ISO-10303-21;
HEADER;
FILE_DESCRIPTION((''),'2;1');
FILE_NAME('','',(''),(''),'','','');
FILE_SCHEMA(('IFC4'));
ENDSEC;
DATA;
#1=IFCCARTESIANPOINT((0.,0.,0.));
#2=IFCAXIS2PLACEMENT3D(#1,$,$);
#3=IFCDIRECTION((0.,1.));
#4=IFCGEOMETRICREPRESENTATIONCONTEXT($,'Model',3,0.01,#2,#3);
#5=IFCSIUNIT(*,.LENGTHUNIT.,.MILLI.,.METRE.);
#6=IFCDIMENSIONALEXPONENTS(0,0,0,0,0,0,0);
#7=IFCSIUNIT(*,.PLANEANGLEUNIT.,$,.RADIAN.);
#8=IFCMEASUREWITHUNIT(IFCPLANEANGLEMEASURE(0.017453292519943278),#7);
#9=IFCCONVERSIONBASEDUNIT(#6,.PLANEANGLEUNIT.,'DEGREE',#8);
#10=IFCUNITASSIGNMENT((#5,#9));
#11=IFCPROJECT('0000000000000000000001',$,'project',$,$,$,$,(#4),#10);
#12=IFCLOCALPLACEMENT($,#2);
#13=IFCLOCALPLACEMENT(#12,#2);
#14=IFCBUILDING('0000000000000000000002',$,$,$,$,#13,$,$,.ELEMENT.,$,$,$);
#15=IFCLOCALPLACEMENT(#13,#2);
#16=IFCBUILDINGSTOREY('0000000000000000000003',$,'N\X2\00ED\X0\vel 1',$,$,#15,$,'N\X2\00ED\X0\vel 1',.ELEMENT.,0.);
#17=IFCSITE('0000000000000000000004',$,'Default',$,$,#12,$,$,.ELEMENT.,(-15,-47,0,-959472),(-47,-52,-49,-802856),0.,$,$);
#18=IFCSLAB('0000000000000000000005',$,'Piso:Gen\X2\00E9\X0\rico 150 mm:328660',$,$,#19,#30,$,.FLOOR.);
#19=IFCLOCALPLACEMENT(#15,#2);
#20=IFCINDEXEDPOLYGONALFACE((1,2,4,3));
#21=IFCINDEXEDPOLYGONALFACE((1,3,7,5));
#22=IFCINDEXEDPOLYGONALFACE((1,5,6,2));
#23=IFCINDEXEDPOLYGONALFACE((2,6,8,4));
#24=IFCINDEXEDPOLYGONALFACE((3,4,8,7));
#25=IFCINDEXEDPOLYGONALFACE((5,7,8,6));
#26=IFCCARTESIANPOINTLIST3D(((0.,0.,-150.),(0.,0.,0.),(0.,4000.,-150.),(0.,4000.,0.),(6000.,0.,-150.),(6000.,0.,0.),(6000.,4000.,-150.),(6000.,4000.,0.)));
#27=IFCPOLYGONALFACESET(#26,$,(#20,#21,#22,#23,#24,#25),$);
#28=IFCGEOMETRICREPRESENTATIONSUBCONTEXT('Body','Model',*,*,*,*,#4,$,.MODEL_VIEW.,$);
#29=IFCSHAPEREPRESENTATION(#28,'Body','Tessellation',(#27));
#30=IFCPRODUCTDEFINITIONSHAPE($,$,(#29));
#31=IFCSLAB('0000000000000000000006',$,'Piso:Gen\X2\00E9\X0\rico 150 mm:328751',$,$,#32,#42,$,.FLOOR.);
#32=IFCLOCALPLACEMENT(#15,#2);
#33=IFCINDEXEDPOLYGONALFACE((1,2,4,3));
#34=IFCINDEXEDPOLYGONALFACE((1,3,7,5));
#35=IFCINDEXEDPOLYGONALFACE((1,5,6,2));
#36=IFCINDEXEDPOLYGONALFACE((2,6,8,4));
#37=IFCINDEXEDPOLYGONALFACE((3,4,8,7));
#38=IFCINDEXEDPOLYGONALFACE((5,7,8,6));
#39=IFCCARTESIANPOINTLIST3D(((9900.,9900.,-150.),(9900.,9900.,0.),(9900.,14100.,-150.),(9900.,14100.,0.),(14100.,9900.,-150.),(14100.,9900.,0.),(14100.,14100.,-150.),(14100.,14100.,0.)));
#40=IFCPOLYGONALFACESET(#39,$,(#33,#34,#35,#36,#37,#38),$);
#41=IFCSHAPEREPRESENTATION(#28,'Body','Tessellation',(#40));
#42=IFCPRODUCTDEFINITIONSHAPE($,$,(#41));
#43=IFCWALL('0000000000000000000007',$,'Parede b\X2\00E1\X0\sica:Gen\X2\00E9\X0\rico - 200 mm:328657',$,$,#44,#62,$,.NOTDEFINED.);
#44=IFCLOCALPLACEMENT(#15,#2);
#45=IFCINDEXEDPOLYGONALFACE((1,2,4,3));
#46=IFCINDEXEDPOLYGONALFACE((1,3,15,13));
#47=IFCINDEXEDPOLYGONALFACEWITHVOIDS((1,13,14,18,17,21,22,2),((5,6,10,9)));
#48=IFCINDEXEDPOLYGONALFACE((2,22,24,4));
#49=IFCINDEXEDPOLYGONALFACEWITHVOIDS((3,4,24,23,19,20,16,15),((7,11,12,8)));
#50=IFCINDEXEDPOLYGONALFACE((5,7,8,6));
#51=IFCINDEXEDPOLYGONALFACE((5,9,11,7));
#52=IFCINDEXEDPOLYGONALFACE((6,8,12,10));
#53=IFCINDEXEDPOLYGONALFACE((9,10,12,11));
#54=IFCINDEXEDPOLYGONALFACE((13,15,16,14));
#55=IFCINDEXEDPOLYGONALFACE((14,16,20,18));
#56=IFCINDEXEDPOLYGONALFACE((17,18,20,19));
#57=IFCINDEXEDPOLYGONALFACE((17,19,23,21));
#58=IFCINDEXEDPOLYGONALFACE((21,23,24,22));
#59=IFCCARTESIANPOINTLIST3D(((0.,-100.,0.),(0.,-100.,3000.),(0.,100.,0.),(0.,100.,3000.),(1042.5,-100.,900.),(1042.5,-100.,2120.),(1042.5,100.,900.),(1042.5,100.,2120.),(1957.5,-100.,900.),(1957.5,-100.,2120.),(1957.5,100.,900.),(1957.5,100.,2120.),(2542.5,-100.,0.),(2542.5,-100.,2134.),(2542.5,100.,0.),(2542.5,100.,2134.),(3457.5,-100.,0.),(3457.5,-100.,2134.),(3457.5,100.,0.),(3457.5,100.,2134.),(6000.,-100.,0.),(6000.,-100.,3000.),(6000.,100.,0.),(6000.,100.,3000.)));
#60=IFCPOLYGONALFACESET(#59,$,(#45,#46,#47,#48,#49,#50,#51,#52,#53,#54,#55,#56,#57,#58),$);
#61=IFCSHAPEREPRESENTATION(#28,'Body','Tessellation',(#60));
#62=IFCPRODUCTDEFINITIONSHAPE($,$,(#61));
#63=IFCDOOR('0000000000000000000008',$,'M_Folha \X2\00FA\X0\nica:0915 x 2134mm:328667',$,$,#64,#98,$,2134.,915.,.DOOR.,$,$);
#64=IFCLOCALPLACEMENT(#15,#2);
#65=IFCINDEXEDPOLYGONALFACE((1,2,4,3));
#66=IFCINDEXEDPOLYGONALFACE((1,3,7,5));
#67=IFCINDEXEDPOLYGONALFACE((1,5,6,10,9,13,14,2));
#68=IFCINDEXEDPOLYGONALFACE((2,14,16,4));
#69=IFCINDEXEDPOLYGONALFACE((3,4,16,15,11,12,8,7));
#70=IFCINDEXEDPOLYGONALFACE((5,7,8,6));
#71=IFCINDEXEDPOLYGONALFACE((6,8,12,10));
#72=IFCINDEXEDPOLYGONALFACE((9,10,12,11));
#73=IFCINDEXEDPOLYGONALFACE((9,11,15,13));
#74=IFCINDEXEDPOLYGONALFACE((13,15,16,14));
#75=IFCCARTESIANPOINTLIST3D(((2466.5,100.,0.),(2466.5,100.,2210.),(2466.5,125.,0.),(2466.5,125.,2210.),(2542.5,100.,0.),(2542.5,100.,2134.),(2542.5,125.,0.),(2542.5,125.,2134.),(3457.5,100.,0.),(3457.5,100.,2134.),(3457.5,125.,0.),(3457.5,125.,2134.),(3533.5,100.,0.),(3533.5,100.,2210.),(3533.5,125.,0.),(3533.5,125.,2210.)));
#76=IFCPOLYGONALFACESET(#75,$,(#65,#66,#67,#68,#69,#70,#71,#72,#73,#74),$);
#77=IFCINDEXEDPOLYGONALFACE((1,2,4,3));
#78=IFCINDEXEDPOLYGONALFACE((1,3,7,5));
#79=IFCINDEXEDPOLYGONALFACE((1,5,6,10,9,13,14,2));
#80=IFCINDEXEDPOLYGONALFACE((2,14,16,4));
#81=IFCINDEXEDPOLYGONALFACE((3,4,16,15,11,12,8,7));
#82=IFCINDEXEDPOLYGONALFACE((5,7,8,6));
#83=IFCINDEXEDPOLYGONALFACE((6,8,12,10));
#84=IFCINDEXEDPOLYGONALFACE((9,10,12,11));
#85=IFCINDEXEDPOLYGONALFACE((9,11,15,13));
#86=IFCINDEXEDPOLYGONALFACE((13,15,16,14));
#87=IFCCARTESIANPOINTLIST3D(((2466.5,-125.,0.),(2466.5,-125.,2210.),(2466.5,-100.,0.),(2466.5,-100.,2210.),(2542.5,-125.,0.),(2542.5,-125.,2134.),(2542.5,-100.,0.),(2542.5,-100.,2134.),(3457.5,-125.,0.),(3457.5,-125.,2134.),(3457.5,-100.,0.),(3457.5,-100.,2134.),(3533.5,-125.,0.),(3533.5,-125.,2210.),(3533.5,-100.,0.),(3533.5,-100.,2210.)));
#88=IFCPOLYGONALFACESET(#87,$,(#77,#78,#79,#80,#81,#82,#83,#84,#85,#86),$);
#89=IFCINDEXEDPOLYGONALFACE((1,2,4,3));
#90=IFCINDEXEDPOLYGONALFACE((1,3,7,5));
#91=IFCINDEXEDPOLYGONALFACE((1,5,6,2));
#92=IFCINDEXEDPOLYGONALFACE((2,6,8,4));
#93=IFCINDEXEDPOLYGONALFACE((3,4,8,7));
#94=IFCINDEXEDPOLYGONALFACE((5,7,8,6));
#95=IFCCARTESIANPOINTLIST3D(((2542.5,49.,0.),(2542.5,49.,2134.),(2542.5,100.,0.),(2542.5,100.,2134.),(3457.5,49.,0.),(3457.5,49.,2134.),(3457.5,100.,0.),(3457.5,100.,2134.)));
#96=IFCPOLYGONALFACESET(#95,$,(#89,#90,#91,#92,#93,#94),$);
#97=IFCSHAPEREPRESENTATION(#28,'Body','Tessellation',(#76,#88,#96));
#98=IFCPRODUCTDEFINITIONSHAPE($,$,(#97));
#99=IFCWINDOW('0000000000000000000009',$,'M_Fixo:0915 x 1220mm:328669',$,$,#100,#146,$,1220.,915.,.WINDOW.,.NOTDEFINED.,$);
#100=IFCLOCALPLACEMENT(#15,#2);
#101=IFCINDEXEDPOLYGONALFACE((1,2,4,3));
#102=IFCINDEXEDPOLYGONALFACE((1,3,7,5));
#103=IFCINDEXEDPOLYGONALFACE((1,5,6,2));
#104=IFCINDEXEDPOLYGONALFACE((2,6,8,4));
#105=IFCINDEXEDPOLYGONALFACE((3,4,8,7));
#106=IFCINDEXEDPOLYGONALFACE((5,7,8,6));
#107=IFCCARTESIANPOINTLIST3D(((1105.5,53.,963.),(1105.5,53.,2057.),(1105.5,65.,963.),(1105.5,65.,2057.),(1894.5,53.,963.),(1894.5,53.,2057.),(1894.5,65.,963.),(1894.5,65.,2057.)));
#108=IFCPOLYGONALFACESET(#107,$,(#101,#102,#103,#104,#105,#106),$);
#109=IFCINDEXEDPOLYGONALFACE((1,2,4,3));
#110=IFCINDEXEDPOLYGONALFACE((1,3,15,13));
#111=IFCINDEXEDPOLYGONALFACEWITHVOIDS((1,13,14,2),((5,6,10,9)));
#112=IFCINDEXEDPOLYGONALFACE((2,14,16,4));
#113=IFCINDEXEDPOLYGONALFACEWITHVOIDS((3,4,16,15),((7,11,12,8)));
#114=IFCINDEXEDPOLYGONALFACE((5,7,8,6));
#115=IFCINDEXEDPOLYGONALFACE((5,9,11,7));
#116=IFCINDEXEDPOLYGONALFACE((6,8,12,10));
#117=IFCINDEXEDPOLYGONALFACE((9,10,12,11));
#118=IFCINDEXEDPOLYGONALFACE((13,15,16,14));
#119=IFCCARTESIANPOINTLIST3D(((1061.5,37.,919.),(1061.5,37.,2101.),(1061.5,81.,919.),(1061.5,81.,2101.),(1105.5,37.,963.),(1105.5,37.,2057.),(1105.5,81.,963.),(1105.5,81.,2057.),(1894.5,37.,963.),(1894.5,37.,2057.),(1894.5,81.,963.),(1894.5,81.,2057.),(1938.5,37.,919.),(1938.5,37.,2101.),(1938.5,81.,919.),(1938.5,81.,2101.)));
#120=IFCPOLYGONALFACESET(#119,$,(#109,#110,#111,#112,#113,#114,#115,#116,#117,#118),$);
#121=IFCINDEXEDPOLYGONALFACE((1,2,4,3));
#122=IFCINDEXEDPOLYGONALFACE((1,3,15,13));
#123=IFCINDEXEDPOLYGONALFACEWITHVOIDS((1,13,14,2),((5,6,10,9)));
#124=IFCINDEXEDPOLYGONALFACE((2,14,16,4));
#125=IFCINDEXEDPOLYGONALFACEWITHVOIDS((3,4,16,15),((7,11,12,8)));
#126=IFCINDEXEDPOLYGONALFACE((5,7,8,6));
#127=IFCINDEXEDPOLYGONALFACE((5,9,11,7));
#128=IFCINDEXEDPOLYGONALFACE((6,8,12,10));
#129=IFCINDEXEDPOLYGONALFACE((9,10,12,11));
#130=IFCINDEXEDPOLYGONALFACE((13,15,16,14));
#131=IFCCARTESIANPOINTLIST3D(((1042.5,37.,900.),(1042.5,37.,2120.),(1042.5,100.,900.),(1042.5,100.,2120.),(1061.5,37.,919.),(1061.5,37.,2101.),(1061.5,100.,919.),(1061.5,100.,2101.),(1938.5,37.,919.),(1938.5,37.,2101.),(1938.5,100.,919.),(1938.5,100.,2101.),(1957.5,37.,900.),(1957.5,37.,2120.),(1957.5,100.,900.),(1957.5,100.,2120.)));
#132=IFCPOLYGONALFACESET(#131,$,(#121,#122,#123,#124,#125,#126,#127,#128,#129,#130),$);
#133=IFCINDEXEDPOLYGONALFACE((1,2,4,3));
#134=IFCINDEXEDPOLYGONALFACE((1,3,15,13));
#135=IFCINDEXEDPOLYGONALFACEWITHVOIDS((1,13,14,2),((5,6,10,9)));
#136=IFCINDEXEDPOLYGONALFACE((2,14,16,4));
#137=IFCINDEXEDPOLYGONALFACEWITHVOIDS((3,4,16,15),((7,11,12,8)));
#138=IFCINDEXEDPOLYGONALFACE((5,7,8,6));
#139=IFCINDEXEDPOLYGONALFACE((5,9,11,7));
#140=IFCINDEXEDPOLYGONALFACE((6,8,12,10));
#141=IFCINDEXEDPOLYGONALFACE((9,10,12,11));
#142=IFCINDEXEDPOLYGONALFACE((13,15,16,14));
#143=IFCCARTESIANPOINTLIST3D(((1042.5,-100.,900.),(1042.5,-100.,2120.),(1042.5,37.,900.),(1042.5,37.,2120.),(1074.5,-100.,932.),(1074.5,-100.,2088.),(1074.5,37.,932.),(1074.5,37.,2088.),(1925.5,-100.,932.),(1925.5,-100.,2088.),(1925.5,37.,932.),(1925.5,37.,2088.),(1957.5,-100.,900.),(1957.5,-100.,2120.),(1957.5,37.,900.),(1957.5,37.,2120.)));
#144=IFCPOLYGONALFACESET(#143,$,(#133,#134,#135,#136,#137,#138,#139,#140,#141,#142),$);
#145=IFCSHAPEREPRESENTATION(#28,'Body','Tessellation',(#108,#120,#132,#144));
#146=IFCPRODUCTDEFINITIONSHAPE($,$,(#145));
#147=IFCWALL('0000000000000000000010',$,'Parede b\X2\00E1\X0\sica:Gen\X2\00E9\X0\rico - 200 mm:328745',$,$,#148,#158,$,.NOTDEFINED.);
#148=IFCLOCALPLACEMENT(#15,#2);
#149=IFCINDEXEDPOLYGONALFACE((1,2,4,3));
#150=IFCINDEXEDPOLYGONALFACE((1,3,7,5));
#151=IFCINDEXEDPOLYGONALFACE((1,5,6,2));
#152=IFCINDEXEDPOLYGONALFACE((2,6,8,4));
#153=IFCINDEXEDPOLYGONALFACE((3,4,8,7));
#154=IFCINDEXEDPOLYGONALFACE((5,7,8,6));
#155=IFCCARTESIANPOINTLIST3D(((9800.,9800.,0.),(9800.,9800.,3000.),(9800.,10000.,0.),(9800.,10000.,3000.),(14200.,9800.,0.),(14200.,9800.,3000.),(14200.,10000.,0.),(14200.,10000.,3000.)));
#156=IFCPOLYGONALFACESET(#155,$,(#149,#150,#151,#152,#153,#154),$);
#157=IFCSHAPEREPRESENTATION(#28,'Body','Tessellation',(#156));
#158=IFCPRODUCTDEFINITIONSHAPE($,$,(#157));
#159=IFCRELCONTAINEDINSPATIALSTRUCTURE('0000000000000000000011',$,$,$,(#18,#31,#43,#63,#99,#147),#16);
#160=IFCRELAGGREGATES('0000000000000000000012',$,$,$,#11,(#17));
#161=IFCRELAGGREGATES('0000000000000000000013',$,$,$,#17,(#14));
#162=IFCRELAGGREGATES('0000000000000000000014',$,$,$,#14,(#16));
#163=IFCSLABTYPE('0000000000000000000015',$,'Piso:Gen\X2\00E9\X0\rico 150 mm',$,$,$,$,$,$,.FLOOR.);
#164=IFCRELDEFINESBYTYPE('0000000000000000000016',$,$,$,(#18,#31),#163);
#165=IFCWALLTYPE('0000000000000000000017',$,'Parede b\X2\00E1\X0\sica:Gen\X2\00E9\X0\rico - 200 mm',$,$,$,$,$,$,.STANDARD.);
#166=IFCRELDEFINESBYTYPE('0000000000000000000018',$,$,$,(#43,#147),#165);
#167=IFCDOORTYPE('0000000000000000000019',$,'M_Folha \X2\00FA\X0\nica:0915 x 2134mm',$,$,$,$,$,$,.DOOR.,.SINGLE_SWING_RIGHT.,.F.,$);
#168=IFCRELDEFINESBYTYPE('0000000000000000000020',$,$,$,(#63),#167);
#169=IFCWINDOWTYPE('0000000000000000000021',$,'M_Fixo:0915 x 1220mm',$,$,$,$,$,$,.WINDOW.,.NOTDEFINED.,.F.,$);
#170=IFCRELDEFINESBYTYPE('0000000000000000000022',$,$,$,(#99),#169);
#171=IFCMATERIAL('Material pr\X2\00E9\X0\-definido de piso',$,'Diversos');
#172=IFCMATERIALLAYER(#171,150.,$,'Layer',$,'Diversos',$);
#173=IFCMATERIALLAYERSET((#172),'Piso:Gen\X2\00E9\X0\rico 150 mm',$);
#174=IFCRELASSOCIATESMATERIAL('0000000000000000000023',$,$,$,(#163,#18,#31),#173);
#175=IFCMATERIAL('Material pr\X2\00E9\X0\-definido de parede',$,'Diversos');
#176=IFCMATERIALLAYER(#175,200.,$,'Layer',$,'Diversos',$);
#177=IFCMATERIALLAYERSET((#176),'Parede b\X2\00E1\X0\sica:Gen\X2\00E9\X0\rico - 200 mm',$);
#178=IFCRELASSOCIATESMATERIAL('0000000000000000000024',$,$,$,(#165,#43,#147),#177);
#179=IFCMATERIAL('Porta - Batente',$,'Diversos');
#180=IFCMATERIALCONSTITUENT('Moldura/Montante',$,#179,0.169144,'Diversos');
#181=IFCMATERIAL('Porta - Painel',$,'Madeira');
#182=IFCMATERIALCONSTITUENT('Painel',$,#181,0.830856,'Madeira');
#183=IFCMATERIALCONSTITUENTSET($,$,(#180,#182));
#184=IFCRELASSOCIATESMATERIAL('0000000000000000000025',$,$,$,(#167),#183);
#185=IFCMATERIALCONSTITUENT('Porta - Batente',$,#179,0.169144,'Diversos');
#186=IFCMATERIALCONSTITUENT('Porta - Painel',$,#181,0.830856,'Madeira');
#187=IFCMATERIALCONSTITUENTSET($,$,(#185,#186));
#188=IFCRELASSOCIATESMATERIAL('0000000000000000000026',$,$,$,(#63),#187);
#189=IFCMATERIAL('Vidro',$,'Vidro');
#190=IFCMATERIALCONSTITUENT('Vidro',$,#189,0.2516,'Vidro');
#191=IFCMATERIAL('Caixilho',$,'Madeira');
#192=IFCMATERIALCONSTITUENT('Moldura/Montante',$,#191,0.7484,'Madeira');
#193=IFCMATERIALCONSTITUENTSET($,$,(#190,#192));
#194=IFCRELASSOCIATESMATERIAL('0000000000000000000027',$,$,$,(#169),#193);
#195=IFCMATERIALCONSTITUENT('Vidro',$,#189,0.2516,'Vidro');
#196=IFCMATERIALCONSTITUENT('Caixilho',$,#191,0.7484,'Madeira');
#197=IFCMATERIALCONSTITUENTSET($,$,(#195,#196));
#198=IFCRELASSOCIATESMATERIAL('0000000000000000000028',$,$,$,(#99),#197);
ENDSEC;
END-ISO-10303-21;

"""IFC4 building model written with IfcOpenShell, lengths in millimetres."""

from ifc_helpers import new_model, entity, si_unit, converted_unit, direction, frame, frame_2d, origin, origin_2d_with_axis, place, context, subcontext, project, spatial, polyline, rectangle, outline, extrude, source, transform, mapped, material, layer, layer_set, layer_usage, constituent, constituent_set, type_object, type_shapes, element, fill, save


model = new_model("IFC4")

# Units and contexts
model_context = context("Model", 3, precision=0.01, world=origin(), true_north=direction((0.0, 1.0)))
body_context = subcontext(model_context, "Body", "Model", "MODEL_VIEW")
ifc_project = project(units=[si_unit("LENGTHUNIT", "METRE", prefix="MILLI"), converted_unit("PLANEANGLEUNIT", "DEGREE", entity("IfcPlaneAngleMeasure", 0.017453292519943278), si_unit("PLANEANGLEUNIT", "RADIAN"), dimensions=[0, 0, 0, 0, 0, 0, 0])], contexts=[model_context])

# Site, building, storey
site_placement = place(None, origin())
site = spatial("IfcSite", under=ifc_project, at=site_placement, Name="Default", CompositionType="ELEMENT", RefLatitude=(-15, -47, 0, -959472), RefLongitude=(-47, -52, -49, -802856), RefElevation=0.0)
building_placement = place(site_placement, origin())
building = spatial("IfcBuilding", under=site, at=building_placement, CompositionType="ELEMENT")
storey_placement = place(building_placement, origin())
storey = spatial("IfcBuildingStorey", under=building, at=storey_placement, Name="Nível 1", LongName="Nível 1", CompositionType="ELEMENT", Elevation=0.0)

# Slabs
ifc_material_1 = material(Name="Material pré-definido de piso", Category="Diversos")
ifc_layer_1 = layer(ifc_material_1, 150.0, Name="Layer", Category="Diversos")
ifc_layer_set_1 = layer_set([ifc_layer_1], Name="Piso:Genérico 150 mm")
ifc_layer_usage_1 = layer_usage(ifc_layer_set_1, "AXIS3", "POSITIVE", 0.0)
slab_type = type_object("IfcSlabType", Name="Piso:Genérico 150 mm", PredefinedType="FLOOR", material=ifc_layer_set_1)
slab_1_placement = place(storey_placement, origin())
element("IfcSlab", 1, at=slab_1_placement, inside=storey, type_object=slab_type, material=ifc_layer_usage_1, Name="Piso:Genérico 150 mm:328660", PredefinedType="FLOOR", context=body_context, shape_type="SweptSolid", body=[
    extrude(rectangle(XDim=4000.0, YDim=6000.0, at=origin_2d_with_axis()), frame((3000.0, 2000.0, 0.0), z_axis=(0.0, 0.0, -1.0), x_axis=(0.0, 1.0, 0.0)), (0.0, 0.0, 1.0), 150.0),
])
ifc_layer_usage_2 = layer_usage(ifc_layer_set_1, "AXIS3", "POSITIVE", 0.0)
slab_2_placement = place(storey_placement, origin())
element("IfcSlab", 2, at=slab_2_placement, inside=storey, type_object=slab_type, material=ifc_layer_usage_2, Name="Piso:Genérico 150 mm:328751", PredefinedType="FLOOR", context=body_context, shape_type="SweptSolid", body=[
    extrude(rectangle(XDim=4200.0, YDim=4200.0, at=origin_2d_with_axis()), frame((12000.0, 12000.0, 0.0), z_axis=(0.0, 0.0, -1.0), x_axis=(0.0, 1.0, 0.0)), (0.0, 0.0, 1.0), 150.0),
])

# Wall, openings, door, window
ifc_material_2 = material(Name="Material pré-definido de parede", Category="Diversos")
ifc_layer_2 = layer(ifc_material_2, 200.0, Name="Layer", Category="Diversos")
ifc_layer_set_2 = layer_set([ifc_layer_2], Name="Parede básica:Genérico - 200 mm")
ifc_layer_usage_3 = layer_usage(ifc_layer_set_2, "AXIS2", "NEGATIVE", 100.0)
wall_type = type_object("IfcWallType", Name="Parede básica:Genérico - 200 mm", PredefinedType="STANDARD", material=ifc_layer_set_2)
wall_1_placement = place(storey_placement, origin())
wall_1 = element("IfcWall", 3, at=wall_1_placement, inside=storey, type_object=wall_type, material=ifc_layer_usage_3, Name="Parede básica:Genérico - 200 mm:328657", PredefinedType="NOTDEFINED", context=body_context, shape_type="SweptSolid", body=[
    extrude(rectangle(XDim=6000.0, YDim=200.0, at=frame_2d((3000.0, 0.0), x_axis=(1.0, 0.0))), origin(), (0.0, 0.0, 1.0), 3000.0),
])
opening_1_placement = place(wall_1_placement, frame((2542.5, -100.0, 0.0)))
opening_1 = element("IfcOpeningElement", 4, at=opening_1_placement, cuts=wall_1, PredefinedType="OPENING", context=body_context, shape_type="SweptSolid", body=[
    extrude(rectangle(XDim=915.0, YDim=2134.0, at=frame_2d((1067.0, 457.5), x_axis=(0.0, 1.0))), frame((0.0, 0.0, 0.0), z_axis=(0.0, 1.0, 0.0), x_axis=(0.0, 0.0, 1.0)), (0.0, 0.0, 1.0), 200.0),
])
opening_2_placement = place(wall_1_placement, frame((1042.5, -100.0, 900.0)))
opening_2 = element("IfcOpeningElement", 5, at=opening_2_placement, cuts=wall_1, PredefinedType="OPENING", context=body_context, shape_type="SweptSolid", body=[
    extrude(rectangle(XDim=1220.0, YDim=915.0, at=frame_2d((610.0, 457.5), x_axis=(1.0, 0.0))), frame((0.0, 0.0, 0.0), z_axis=(0.0, 1.0, 0.0), x_axis=(0.0, 0.0, 1.0)), (0.0, 0.0, 1.0), 200.0),
])
ifc_material_3 = material(Name="Porta - Batente", Category="Diversos")
ifc_constituent_1 = constituent(ifc_material_3, Name="Porta - Batente", Category="Diversos", fraction=0.169144)
ifc_material_4 = material(Name="Porta - Painel", Category="Madeira")
ifc_constituent_2 = constituent(ifc_material_4, Name="Porta - Painel", Category="Madeira", fraction=0.830856)
ifc_constituent_set_1 = constituent_set(constituents=[ifc_constituent_1, ifc_constituent_2])
ifc_constituent_3 = constituent(ifc_material_3, Name="Moldura/Montante", Category="Diversos", fraction=0.169144)
ifc_constituent_4 = constituent(ifc_material_4, Name="Painel", Category="Madeira", fraction=0.830856)
ifc_constituent_set_2 = constituent_set(constituents=[ifc_constituent_3, ifc_constituent_4])
door_type = type_object("IfcDoorType", Name="M_Folha única:0915 x 2134mm", OperationType="SINGLE_SWING_RIGHT", ParameterTakesPrecedence=False, PredefinedType="DOOR", material=ifc_constituent_set_2)
shared_shape_1 = source(origin(), body_context, "Body", "SweptSolid", [
    extrude(outline(polyline([(-533.5, -1124.0), (533.5, -1124.0), (533.5, 1086.0), (457.5, 1086.0), (457.5, -1048.0), (-457.5, -1048.0), (-457.5, 1086.0), (-533.5, 1086.0), (-533.5, -1124.0)])), frame((457.5, 200.0, 1086.0), z_axis=(0.0, 1.0, 0.0), x_axis=(1.0, 0.0, 0.0)), (0.0, 0.0, 1.0), 25.0),
    extrude(outline(polyline([(-1124.0, -533.5), (1086.0, -533.5), (1086.0, -457.5), (-1048.0, -457.5), (-1048.0, 457.5), (1086.0, 457.5), (1086.0, 533.5), (-1124.0, 533.5), (-1124.0, -533.5)])), frame((457.5, -25.0, 1086.0), z_axis=(0.0, 1.0, 0.0), x_axis=(0.0, 0.0, -1.0)), (0.0, 0.0, 1.0), 25.0),
    extrude(rectangle(XDim=51.0, YDim=915.0, at=frame_2d((0.0, 0.0), x_axis=(1.0, 0.0))), frame((457.5, 174.5, 0.0), z_axis=(0.0, 0.0, 1.0), x_axis=(0.0, 1.0, 0.0)), (0.0, 0.0, 1.0), 2134.0),
])
type_shapes(door_type, [shared_shape_1])
door_placement = place(opening_1_placement, origin())
door = element("IfcDoor", 6, at=door_placement, inside=storey, type_object=door_type, material=ifc_constituent_set_1, Name="M_Folha única:0915 x 2134mm:328667", OverallHeight=2134.0, OverallWidth=915.0, PredefinedType="DOOR", context=body_context, shape_type="MappedRepresentation", body=[
    mapped(shared_shape_1, transform((0.0, 0.0, 0.0), scale=1.0)),
])
fill(opening_1, door)
ifc_material_5 = material(Name="Vidro", Category="Vidro")
ifc_constituent_5 = constituent(ifc_material_5, Name="Vidro", Category="Vidro", fraction=0.2516)
ifc_material_6 = material(Name="Caixilho", Category="Madeira")
ifc_constituent_6 = constituent(ifc_material_6, Name="Caixilho", Category="Madeira", fraction=0.7484)
ifc_constituent_set_3 = constituent_set(constituents=[ifc_constituent_5, ifc_constituent_6])
ifc_constituent_7 = constituent(ifc_material_5, Name="Vidro", Category="Vidro", fraction=0.2516)
ifc_constituent_8 = constituent(ifc_material_6, Name="Moldura/Montante", Category="Madeira", fraction=0.7484)
ifc_constituent_set_4 = constituent_set(constituents=[ifc_constituent_7, ifc_constituent_8])
window_type = type_object("IfcWindowType", Name="M_Fixo:0915 x 1220mm", ParameterTakesPrecedence=False, PartitioningType="NOTDEFINED", PredefinedType="WINDOW", material=ifc_constituent_set_4)
shared_shape_2 = source(origin(), body_context, "Body", "SweptSolid", [
    extrude(rectangle(XDim=12.0, YDim=789.0, at=frame_2d((0.0, 0.0), x_axis=(1.0, 0.0))), frame((457.5, 159.0, 63.0), z_axis=(0.0, 0.0, 1.0), x_axis=(0.0, -1.0, 0.0)), (0.0, 0.0, 1.0), 1094.0),
    extrude(outline(polyline([(-438.5, -591.0), (438.5, -591.0), (438.5, 591.0), (-438.5, 591.0), (-438.5, -591.0)]), holes=[polyline([(-394.5, -547.0), (-394.5, 547.0), (394.5, 547.0), (394.5, -547.0), (-394.5, -547.0)])]), frame((457.5, 137.0, 610.0), z_axis=(0.0, 1.0, 0.0), x_axis=(1.0, 0.0, 0.0)), (0.0, 0.0, 1.0), 44.0),
    extrude(outline(polyline([(-457.5, -610.0), (457.5, -610.0), (457.5, 610.0), (-457.5, 610.0), (-457.5, -610.0)]), holes=[polyline([(-438.5, -591.0), (-438.5, 591.0), (438.5, 591.0), (438.5, -591.0), (-438.5, -591.0)])]), frame((457.5, 137.0, 610.0), z_axis=(0.0, 1.0, 0.0), x_axis=(1.0, 0.0, 0.0)), (0.0, 0.0, 1.0), 63.0),
    extrude(outline(polyline([(-457.5, -610.0), (457.5, -610.0), (457.5, 610.0), (-457.5, 610.0), (-457.5, -610.0)]), holes=[polyline([(-425.5, -578.0), (-425.5, 578.0), (425.5, 578.0), (425.5, -578.0), (-425.5, -578.0)])]), frame((457.5, 0.0, 610.0), z_axis=(0.0, 1.0, 0.0), x_axis=(1.0, 0.0, 0.0)), (0.0, 0.0, 1.0), 137.0),
])
type_shapes(window_type, [shared_shape_2])
window_placement = place(opening_2_placement, origin())
window = element("IfcWindow", 7, at=window_placement, inside=storey, type_object=window_type, material=ifc_constituent_set_3, Name="M_Fixo:0915 x 1220mm:328669", OverallHeight=1220.0, OverallWidth=915.0, PartitioningType="NOTDEFINED", PredefinedType="WINDOW", context=body_context, shape_type="MappedRepresentation", body=[
    mapped(shared_shape_2, transform((0.0, 0.0, 0.0), scale=1.0)),
])
fill(opening_2, window)

# Wall
ifc_layer_usage_4 = layer_usage(ifc_layer_set_2, "AXIS2", "NEGATIVE", 100.0)
wall_2_placement = place(storey_placement, frame((9800.0, 9900.0, 0.0)))
element("IfcWall", 8, at=wall_2_placement, inside=storey, type_object=wall_type, material=ifc_layer_usage_4, Name="Parede básica:Genérico - 200 mm:328745", PredefinedType="NOTDEFINED", context=body_context, shape_type="SweptSolid", body=[
    extrude(rectangle(XDim=4400.0, YDim=200.0, at=frame_2d((2200.0, 0.0), x_axis=(-1.0, 0.0))), origin(), (0.0, 0.0, 1.0), 3000.0),
])

save(model, "model.ifc")
